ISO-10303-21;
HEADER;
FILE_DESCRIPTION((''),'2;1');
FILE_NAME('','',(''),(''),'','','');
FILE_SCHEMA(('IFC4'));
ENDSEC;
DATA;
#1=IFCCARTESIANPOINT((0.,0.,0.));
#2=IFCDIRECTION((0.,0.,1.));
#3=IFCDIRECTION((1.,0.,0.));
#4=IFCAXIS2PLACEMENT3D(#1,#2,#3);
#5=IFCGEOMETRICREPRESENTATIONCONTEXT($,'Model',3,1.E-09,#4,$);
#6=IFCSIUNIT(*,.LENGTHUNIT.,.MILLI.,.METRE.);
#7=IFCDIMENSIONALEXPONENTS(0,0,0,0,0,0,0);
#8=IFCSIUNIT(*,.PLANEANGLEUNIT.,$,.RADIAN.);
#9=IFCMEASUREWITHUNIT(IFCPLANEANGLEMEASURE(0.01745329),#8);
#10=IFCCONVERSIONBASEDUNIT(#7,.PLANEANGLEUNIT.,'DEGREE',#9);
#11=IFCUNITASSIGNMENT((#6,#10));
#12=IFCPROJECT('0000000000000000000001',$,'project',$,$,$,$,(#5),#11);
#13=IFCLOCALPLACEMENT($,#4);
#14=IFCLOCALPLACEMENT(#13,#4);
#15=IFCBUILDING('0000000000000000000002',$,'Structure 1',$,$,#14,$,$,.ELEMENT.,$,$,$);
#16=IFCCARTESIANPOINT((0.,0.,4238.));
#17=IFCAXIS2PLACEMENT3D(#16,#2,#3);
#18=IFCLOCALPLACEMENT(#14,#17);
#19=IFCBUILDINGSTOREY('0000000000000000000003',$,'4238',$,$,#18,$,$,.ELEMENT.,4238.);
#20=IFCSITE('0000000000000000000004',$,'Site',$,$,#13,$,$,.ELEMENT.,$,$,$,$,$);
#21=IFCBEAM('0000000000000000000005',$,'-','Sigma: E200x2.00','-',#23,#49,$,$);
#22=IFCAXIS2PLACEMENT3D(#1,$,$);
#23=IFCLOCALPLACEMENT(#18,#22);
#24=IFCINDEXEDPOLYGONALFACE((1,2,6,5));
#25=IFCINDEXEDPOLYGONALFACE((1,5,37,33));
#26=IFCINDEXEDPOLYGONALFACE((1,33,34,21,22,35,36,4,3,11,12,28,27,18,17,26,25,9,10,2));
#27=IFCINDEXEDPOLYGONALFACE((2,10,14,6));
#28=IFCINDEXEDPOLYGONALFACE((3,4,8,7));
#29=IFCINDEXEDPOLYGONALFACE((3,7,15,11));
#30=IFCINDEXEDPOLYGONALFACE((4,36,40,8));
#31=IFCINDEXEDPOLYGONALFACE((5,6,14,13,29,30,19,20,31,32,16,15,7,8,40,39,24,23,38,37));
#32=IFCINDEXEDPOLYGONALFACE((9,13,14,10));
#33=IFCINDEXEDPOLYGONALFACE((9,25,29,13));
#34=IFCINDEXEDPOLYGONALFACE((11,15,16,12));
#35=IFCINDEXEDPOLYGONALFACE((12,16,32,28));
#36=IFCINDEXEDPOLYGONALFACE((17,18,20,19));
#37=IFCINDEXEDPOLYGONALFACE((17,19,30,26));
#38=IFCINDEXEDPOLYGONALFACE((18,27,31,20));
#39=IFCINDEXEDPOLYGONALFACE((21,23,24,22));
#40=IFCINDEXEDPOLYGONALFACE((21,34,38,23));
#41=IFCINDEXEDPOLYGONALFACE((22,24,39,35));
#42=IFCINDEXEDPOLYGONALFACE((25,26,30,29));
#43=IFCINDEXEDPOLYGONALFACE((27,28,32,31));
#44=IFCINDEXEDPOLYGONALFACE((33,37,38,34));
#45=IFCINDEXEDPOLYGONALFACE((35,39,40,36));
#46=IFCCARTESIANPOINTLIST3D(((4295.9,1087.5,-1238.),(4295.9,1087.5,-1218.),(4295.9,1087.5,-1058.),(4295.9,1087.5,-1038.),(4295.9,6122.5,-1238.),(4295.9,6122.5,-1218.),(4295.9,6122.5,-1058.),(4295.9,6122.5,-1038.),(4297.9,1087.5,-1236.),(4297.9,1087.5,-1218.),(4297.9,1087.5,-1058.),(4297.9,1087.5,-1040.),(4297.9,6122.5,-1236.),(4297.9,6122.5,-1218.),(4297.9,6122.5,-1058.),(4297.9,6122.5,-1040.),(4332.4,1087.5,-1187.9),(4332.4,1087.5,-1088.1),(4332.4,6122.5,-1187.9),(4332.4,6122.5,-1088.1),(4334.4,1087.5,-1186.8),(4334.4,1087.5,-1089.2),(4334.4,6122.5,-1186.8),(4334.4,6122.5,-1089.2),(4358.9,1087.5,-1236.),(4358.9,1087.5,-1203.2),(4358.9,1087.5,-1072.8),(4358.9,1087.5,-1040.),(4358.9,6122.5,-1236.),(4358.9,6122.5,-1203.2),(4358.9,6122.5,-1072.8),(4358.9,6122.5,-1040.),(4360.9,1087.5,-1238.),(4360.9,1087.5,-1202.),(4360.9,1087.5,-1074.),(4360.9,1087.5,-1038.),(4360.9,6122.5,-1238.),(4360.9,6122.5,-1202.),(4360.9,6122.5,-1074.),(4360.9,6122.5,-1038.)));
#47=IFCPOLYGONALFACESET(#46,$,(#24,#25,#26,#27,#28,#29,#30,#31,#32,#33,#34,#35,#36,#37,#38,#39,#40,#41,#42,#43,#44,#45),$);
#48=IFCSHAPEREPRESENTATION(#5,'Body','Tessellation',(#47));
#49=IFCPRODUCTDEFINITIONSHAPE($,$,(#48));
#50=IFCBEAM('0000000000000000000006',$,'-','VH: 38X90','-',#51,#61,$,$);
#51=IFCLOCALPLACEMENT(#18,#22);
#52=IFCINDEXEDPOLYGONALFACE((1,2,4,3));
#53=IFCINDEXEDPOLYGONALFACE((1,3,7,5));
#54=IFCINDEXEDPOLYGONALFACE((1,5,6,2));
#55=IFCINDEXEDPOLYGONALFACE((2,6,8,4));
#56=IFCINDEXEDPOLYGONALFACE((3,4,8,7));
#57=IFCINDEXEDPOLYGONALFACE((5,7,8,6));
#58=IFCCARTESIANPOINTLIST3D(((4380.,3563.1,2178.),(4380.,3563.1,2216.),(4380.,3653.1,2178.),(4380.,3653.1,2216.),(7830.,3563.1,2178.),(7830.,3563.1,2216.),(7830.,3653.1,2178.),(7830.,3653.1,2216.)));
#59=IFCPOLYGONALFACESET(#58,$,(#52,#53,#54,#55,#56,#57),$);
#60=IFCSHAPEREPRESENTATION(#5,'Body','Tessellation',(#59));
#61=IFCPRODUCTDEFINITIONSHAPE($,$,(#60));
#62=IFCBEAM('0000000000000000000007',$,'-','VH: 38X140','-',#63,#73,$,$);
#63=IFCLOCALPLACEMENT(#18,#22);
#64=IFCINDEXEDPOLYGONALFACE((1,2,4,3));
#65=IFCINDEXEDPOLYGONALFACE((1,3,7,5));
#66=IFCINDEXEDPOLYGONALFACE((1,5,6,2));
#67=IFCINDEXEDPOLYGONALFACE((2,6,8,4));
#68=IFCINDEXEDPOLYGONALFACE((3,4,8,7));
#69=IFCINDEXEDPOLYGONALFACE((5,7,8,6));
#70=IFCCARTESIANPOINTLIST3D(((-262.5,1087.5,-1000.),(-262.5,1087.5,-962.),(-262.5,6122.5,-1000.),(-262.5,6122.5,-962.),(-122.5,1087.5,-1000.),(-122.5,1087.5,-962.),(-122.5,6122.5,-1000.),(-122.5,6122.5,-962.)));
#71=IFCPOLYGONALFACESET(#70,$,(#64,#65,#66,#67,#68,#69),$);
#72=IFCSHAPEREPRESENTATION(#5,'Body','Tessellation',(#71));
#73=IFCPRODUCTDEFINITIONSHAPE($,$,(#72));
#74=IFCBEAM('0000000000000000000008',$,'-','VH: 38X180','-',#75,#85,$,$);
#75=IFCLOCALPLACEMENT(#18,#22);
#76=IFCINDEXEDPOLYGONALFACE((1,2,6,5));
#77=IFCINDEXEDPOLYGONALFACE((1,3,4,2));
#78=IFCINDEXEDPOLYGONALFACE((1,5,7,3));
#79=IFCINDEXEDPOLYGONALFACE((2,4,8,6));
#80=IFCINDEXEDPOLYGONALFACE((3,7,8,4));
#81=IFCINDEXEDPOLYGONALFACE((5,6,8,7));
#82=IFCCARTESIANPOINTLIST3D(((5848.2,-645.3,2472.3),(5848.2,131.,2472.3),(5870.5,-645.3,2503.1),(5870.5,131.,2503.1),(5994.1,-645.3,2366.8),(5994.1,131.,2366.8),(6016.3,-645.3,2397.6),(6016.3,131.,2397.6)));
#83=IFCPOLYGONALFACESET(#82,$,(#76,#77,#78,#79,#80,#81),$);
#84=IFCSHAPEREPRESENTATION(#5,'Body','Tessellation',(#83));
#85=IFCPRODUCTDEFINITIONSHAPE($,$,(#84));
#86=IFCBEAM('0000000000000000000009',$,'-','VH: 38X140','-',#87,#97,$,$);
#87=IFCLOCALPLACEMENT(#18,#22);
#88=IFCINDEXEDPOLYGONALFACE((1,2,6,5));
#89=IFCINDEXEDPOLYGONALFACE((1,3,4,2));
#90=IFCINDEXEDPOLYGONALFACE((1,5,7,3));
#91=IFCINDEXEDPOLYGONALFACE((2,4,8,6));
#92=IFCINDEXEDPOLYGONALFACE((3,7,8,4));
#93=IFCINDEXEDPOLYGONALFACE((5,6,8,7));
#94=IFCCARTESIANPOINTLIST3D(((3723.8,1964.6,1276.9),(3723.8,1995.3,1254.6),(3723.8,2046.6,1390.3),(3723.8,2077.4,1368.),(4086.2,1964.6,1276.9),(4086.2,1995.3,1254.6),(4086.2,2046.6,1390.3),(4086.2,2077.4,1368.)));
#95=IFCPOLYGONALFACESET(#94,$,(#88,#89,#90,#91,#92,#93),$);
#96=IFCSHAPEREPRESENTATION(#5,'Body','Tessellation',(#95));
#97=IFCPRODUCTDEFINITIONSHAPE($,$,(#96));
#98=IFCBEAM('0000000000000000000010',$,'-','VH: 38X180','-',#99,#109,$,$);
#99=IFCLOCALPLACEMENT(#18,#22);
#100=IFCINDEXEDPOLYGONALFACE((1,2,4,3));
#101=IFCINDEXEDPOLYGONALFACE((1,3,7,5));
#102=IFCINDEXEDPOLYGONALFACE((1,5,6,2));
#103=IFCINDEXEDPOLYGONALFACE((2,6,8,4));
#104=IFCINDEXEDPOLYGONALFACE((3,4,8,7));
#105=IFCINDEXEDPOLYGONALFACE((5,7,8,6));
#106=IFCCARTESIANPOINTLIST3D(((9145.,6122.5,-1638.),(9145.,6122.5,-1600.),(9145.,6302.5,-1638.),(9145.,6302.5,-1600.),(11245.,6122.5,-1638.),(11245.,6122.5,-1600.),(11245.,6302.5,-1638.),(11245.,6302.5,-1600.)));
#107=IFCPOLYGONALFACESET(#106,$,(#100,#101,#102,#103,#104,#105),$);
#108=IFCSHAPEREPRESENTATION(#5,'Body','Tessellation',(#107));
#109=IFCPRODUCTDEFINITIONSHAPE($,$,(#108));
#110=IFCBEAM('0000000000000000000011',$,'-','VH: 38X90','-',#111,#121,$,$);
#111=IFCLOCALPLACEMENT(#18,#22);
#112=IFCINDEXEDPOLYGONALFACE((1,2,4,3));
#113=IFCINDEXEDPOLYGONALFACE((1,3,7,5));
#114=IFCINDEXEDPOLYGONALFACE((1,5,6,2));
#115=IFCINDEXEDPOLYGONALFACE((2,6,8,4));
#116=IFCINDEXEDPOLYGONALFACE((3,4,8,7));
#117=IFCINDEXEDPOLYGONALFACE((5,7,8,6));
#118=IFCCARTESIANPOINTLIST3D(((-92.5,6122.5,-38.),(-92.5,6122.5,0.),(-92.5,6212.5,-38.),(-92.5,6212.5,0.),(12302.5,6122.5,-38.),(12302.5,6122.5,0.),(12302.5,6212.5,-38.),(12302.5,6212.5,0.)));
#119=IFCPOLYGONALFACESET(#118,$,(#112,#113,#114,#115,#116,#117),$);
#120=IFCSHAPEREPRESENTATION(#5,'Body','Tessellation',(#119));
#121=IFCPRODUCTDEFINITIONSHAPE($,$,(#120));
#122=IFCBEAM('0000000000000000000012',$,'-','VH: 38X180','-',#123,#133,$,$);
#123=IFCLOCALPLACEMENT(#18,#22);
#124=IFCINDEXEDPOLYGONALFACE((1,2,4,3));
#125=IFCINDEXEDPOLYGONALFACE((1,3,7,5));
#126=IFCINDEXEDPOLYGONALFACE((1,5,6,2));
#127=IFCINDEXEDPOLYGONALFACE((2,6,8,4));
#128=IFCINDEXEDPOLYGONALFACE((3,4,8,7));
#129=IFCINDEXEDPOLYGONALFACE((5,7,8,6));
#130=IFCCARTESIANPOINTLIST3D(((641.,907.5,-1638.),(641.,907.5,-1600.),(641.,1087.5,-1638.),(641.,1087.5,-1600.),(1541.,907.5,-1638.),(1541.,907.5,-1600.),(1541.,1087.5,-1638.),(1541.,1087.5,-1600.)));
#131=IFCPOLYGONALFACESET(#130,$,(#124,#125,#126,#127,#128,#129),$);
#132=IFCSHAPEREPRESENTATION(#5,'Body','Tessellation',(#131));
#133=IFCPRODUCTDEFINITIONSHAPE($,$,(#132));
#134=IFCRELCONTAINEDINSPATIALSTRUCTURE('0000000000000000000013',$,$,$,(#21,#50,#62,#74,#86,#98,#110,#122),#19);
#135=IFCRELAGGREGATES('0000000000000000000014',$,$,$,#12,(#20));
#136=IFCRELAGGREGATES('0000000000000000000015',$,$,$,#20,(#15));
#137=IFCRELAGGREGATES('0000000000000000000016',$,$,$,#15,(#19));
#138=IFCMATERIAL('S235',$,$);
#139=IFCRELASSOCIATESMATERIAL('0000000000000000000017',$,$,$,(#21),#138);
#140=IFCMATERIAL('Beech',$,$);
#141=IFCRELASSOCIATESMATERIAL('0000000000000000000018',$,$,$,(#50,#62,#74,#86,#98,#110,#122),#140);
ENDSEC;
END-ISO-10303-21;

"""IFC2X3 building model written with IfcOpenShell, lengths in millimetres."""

from ifc_helpers import new_model, entity, si_unit, converted_unit, frame, origin, origin_with_axes, origin_2d, place, context, project, spatial, polyline, rectangle, outline, extrude, material, element, save


model = new_model("IFC2X3")

# Units and contexts
model_context = context("Model", 3, precision=1e-09, world=origin_with_axes())
ifc_project = project(units=[si_unit("LENGTHUNIT", "METRE", prefix="MILLI"), converted_unit("PLANEANGLEUNIT", "DEGREE", entity("IfcPlaneAngleMeasure", 0.01745329), si_unit("PLANEANGLEUNIT", "RADIAN"), dimensions=[0, 0, 0, 0, 0, 0, 0])], contexts=[model_context])

# Site, building, storey
site_placement = place(None, origin_with_axes())
site = spatial("IfcSite", under=ifc_project, at=site_placement, Name="Site", CompositionType="ELEMENT")
building_placement = place(site_placement, origin_with_axes())
building = spatial("IfcBuilding", under=site, at=building_placement, Name="Structure 1", CompositionType="ELEMENT")
storey_placement = place(building_placement, frame((0.0, 0.0, 4238.0), z_axis=(0.0, 0.0, 1.0), x_axis=(1.0, 0.0, 0.0)))
storey = spatial("IfcBuildingStorey", under=building, at=storey_placement, Name="4238", CompositionType="ELEMENT", Elevation=4238.0)

# Shared definitions
ifc_material_1 = material(Name="S235")
ifc_material_2 = material(Name="Beech")

# Beams
beam_1_placement = place(None, frame((4335.0, 1087.5, 3100.0), z_axis=(0.0, 1.0, 0.0), x_axis=(-1.0, 0.0, 0.0)))
element("IfcBeam", 1, at=beam_1_placement, inside=storey, material=ifc_material_1, Name="-", Description="Sigma: E200x2.00", ObjectType="-", context=model_context, shape_type="SweptSolid", body=[
    extrude(outline(polyline([(39.1, -100.0), (39.1, -80.0), (37.1, -80.0), (37.1, -98.0), (-23.9, -98.0), (-23.9, -65.2), (2.6, -49.9), (2.6, 49.9), (-23.9, 65.2), (-23.9, 98.0), (37.1, 98.0), (37.1, 80.0), (39.1, 80.0), (39.1, 100.0), (-25.9, 100.0), (-25.9, 64.0), (0.6, 48.8), (0.6, -48.8), (-25.9, -64.0), (-25.9, -100.0), (39.1, -100.0)])), origin(), (0.0, 0.0, 1.0), 5035.0),
])
beam_2_placement = place(None, frame((4380.0, 3608.1, 6435.0), z_axis=(-1.0, 0.0, 0.0), x_axis=(0.0, 0.0, -1.0)))
element("IfcBeam", 2, at=beam_2_placement, inside=storey, material=ifc_material_2, Name="-", Description="VH: 38X90", ObjectType="-", context=model_context, shape_type="SweptSolid", body=[
    extrude(rectangle(XDim=38.0, YDim=90.0, at=origin_2d()), origin(), (0.0, 0.0, -1.0), 3450.0),
])
beam_3_placement = place(None, frame((-192.5, 6122.5, 3257.0), z_axis=(0.000003, 1.0, 0.0), x_axis=(0.0, 0.0, -1.0)))
element("IfcBeam", 3, at=beam_3_placement, inside=storey, material=ifc_material_2, Name="-", Description="VH: 38X140", ObjectType="-", context=model_context, shape_type="SweptSolid", body=[
    extrude(rectangle(XDim=38.0, YDim=140.0, at=origin_2d()), origin(), (0.0, 0.0, -1.0), 5035.0),
])
beam_4_placement = place(None, frame((5932.3, 131.0, 6673.0), z_axis=(0.0, 1.0, 0.0), x_axis=(0.58623, 0.0, 0.810145)))
element("IfcBeam", 4, at=beam_4_placement, inside=storey, material=ifc_material_2, Name="-", Description="VH: 38X180", ObjectType="-", context=model_context, shape_type="SweptSolid", body=[
    extrude(rectangle(XDim=38.0, YDim=180.0, at=origin_2d()), origin(), (0.0, 0.0, -1.0), 776.3),
])
beam_5_placement = place(None, frame((3723.8, 2021.0, 5560.4), z_axis=(-1.0, 0.000006, -0.000004), x_axis=(0.000007, 0.810145, -0.58623)))
element("IfcBeam", 5, at=beam_5_placement, inside=storey, material=ifc_material_2, Name="-", Description="VH: 38X140", ObjectType="-", context=model_context, shape_type="SweptSolid", body=[
    extrude(rectangle(XDim=38.0, YDim=140.0, at=origin_2d()), origin(), (0.0, 0.0, -1.0), 362.5),
])
beam_6_placement = place(None, frame((11245.0, 6212.5, 2619.0), z_axis=(1.0, 0.0, 0.0), x_axis=(0.0, 0.0, -1.0)))
element("IfcBeam", 6, at=beam_6_placement, inside=storey, material=ifc_material_2, Name="-", Description="VH: 38X180", ObjectType="-", context=model_context, shape_type="SweptSolid", body=[
    extrude(rectangle(XDim=38.0, YDim=180.0, at=origin_2d()), origin(), (0.0, 0.0, -1.0), 2100.0),
])
beam_7_placement = place(None, frame((-92.5, 6167.5, 4219.0), z_axis=(-1.0, 0.0, 0.0), x_axis=(0.0, 0.0, 1.0)))
element("IfcBeam", 7, at=beam_7_placement, inside=storey, material=ifc_material_2, Name="-", Description="VH: 38X90", ObjectType="-", context=model_context, shape_type="SweptSolid", body=[
    extrude(rectangle(XDim=38.0, YDim=90.0, at=origin_2d()), origin(), (0.0, 0.0, -1.0), 12395.0),
])
beam_8_placement = place(None, frame((641.0, 997.5, 2619.0), z_axis=(-1.0, 0.0, 0.0), x_axis=(0.0, 0.0, -1.0)))
element("IfcBeam", 8, at=beam_8_placement, inside=storey, material=ifc_material_2, Name="-", Description="VH: 38X180", ObjectType="-", context=model_context, shape_type="SweptSolid", body=[
    extrude(rectangle(XDim=38.0, YDim=180.0, at=origin_2d()), origin(), (0.0, 0.0, -1.0), 900.0),
])

save(model, "model.ifc")
